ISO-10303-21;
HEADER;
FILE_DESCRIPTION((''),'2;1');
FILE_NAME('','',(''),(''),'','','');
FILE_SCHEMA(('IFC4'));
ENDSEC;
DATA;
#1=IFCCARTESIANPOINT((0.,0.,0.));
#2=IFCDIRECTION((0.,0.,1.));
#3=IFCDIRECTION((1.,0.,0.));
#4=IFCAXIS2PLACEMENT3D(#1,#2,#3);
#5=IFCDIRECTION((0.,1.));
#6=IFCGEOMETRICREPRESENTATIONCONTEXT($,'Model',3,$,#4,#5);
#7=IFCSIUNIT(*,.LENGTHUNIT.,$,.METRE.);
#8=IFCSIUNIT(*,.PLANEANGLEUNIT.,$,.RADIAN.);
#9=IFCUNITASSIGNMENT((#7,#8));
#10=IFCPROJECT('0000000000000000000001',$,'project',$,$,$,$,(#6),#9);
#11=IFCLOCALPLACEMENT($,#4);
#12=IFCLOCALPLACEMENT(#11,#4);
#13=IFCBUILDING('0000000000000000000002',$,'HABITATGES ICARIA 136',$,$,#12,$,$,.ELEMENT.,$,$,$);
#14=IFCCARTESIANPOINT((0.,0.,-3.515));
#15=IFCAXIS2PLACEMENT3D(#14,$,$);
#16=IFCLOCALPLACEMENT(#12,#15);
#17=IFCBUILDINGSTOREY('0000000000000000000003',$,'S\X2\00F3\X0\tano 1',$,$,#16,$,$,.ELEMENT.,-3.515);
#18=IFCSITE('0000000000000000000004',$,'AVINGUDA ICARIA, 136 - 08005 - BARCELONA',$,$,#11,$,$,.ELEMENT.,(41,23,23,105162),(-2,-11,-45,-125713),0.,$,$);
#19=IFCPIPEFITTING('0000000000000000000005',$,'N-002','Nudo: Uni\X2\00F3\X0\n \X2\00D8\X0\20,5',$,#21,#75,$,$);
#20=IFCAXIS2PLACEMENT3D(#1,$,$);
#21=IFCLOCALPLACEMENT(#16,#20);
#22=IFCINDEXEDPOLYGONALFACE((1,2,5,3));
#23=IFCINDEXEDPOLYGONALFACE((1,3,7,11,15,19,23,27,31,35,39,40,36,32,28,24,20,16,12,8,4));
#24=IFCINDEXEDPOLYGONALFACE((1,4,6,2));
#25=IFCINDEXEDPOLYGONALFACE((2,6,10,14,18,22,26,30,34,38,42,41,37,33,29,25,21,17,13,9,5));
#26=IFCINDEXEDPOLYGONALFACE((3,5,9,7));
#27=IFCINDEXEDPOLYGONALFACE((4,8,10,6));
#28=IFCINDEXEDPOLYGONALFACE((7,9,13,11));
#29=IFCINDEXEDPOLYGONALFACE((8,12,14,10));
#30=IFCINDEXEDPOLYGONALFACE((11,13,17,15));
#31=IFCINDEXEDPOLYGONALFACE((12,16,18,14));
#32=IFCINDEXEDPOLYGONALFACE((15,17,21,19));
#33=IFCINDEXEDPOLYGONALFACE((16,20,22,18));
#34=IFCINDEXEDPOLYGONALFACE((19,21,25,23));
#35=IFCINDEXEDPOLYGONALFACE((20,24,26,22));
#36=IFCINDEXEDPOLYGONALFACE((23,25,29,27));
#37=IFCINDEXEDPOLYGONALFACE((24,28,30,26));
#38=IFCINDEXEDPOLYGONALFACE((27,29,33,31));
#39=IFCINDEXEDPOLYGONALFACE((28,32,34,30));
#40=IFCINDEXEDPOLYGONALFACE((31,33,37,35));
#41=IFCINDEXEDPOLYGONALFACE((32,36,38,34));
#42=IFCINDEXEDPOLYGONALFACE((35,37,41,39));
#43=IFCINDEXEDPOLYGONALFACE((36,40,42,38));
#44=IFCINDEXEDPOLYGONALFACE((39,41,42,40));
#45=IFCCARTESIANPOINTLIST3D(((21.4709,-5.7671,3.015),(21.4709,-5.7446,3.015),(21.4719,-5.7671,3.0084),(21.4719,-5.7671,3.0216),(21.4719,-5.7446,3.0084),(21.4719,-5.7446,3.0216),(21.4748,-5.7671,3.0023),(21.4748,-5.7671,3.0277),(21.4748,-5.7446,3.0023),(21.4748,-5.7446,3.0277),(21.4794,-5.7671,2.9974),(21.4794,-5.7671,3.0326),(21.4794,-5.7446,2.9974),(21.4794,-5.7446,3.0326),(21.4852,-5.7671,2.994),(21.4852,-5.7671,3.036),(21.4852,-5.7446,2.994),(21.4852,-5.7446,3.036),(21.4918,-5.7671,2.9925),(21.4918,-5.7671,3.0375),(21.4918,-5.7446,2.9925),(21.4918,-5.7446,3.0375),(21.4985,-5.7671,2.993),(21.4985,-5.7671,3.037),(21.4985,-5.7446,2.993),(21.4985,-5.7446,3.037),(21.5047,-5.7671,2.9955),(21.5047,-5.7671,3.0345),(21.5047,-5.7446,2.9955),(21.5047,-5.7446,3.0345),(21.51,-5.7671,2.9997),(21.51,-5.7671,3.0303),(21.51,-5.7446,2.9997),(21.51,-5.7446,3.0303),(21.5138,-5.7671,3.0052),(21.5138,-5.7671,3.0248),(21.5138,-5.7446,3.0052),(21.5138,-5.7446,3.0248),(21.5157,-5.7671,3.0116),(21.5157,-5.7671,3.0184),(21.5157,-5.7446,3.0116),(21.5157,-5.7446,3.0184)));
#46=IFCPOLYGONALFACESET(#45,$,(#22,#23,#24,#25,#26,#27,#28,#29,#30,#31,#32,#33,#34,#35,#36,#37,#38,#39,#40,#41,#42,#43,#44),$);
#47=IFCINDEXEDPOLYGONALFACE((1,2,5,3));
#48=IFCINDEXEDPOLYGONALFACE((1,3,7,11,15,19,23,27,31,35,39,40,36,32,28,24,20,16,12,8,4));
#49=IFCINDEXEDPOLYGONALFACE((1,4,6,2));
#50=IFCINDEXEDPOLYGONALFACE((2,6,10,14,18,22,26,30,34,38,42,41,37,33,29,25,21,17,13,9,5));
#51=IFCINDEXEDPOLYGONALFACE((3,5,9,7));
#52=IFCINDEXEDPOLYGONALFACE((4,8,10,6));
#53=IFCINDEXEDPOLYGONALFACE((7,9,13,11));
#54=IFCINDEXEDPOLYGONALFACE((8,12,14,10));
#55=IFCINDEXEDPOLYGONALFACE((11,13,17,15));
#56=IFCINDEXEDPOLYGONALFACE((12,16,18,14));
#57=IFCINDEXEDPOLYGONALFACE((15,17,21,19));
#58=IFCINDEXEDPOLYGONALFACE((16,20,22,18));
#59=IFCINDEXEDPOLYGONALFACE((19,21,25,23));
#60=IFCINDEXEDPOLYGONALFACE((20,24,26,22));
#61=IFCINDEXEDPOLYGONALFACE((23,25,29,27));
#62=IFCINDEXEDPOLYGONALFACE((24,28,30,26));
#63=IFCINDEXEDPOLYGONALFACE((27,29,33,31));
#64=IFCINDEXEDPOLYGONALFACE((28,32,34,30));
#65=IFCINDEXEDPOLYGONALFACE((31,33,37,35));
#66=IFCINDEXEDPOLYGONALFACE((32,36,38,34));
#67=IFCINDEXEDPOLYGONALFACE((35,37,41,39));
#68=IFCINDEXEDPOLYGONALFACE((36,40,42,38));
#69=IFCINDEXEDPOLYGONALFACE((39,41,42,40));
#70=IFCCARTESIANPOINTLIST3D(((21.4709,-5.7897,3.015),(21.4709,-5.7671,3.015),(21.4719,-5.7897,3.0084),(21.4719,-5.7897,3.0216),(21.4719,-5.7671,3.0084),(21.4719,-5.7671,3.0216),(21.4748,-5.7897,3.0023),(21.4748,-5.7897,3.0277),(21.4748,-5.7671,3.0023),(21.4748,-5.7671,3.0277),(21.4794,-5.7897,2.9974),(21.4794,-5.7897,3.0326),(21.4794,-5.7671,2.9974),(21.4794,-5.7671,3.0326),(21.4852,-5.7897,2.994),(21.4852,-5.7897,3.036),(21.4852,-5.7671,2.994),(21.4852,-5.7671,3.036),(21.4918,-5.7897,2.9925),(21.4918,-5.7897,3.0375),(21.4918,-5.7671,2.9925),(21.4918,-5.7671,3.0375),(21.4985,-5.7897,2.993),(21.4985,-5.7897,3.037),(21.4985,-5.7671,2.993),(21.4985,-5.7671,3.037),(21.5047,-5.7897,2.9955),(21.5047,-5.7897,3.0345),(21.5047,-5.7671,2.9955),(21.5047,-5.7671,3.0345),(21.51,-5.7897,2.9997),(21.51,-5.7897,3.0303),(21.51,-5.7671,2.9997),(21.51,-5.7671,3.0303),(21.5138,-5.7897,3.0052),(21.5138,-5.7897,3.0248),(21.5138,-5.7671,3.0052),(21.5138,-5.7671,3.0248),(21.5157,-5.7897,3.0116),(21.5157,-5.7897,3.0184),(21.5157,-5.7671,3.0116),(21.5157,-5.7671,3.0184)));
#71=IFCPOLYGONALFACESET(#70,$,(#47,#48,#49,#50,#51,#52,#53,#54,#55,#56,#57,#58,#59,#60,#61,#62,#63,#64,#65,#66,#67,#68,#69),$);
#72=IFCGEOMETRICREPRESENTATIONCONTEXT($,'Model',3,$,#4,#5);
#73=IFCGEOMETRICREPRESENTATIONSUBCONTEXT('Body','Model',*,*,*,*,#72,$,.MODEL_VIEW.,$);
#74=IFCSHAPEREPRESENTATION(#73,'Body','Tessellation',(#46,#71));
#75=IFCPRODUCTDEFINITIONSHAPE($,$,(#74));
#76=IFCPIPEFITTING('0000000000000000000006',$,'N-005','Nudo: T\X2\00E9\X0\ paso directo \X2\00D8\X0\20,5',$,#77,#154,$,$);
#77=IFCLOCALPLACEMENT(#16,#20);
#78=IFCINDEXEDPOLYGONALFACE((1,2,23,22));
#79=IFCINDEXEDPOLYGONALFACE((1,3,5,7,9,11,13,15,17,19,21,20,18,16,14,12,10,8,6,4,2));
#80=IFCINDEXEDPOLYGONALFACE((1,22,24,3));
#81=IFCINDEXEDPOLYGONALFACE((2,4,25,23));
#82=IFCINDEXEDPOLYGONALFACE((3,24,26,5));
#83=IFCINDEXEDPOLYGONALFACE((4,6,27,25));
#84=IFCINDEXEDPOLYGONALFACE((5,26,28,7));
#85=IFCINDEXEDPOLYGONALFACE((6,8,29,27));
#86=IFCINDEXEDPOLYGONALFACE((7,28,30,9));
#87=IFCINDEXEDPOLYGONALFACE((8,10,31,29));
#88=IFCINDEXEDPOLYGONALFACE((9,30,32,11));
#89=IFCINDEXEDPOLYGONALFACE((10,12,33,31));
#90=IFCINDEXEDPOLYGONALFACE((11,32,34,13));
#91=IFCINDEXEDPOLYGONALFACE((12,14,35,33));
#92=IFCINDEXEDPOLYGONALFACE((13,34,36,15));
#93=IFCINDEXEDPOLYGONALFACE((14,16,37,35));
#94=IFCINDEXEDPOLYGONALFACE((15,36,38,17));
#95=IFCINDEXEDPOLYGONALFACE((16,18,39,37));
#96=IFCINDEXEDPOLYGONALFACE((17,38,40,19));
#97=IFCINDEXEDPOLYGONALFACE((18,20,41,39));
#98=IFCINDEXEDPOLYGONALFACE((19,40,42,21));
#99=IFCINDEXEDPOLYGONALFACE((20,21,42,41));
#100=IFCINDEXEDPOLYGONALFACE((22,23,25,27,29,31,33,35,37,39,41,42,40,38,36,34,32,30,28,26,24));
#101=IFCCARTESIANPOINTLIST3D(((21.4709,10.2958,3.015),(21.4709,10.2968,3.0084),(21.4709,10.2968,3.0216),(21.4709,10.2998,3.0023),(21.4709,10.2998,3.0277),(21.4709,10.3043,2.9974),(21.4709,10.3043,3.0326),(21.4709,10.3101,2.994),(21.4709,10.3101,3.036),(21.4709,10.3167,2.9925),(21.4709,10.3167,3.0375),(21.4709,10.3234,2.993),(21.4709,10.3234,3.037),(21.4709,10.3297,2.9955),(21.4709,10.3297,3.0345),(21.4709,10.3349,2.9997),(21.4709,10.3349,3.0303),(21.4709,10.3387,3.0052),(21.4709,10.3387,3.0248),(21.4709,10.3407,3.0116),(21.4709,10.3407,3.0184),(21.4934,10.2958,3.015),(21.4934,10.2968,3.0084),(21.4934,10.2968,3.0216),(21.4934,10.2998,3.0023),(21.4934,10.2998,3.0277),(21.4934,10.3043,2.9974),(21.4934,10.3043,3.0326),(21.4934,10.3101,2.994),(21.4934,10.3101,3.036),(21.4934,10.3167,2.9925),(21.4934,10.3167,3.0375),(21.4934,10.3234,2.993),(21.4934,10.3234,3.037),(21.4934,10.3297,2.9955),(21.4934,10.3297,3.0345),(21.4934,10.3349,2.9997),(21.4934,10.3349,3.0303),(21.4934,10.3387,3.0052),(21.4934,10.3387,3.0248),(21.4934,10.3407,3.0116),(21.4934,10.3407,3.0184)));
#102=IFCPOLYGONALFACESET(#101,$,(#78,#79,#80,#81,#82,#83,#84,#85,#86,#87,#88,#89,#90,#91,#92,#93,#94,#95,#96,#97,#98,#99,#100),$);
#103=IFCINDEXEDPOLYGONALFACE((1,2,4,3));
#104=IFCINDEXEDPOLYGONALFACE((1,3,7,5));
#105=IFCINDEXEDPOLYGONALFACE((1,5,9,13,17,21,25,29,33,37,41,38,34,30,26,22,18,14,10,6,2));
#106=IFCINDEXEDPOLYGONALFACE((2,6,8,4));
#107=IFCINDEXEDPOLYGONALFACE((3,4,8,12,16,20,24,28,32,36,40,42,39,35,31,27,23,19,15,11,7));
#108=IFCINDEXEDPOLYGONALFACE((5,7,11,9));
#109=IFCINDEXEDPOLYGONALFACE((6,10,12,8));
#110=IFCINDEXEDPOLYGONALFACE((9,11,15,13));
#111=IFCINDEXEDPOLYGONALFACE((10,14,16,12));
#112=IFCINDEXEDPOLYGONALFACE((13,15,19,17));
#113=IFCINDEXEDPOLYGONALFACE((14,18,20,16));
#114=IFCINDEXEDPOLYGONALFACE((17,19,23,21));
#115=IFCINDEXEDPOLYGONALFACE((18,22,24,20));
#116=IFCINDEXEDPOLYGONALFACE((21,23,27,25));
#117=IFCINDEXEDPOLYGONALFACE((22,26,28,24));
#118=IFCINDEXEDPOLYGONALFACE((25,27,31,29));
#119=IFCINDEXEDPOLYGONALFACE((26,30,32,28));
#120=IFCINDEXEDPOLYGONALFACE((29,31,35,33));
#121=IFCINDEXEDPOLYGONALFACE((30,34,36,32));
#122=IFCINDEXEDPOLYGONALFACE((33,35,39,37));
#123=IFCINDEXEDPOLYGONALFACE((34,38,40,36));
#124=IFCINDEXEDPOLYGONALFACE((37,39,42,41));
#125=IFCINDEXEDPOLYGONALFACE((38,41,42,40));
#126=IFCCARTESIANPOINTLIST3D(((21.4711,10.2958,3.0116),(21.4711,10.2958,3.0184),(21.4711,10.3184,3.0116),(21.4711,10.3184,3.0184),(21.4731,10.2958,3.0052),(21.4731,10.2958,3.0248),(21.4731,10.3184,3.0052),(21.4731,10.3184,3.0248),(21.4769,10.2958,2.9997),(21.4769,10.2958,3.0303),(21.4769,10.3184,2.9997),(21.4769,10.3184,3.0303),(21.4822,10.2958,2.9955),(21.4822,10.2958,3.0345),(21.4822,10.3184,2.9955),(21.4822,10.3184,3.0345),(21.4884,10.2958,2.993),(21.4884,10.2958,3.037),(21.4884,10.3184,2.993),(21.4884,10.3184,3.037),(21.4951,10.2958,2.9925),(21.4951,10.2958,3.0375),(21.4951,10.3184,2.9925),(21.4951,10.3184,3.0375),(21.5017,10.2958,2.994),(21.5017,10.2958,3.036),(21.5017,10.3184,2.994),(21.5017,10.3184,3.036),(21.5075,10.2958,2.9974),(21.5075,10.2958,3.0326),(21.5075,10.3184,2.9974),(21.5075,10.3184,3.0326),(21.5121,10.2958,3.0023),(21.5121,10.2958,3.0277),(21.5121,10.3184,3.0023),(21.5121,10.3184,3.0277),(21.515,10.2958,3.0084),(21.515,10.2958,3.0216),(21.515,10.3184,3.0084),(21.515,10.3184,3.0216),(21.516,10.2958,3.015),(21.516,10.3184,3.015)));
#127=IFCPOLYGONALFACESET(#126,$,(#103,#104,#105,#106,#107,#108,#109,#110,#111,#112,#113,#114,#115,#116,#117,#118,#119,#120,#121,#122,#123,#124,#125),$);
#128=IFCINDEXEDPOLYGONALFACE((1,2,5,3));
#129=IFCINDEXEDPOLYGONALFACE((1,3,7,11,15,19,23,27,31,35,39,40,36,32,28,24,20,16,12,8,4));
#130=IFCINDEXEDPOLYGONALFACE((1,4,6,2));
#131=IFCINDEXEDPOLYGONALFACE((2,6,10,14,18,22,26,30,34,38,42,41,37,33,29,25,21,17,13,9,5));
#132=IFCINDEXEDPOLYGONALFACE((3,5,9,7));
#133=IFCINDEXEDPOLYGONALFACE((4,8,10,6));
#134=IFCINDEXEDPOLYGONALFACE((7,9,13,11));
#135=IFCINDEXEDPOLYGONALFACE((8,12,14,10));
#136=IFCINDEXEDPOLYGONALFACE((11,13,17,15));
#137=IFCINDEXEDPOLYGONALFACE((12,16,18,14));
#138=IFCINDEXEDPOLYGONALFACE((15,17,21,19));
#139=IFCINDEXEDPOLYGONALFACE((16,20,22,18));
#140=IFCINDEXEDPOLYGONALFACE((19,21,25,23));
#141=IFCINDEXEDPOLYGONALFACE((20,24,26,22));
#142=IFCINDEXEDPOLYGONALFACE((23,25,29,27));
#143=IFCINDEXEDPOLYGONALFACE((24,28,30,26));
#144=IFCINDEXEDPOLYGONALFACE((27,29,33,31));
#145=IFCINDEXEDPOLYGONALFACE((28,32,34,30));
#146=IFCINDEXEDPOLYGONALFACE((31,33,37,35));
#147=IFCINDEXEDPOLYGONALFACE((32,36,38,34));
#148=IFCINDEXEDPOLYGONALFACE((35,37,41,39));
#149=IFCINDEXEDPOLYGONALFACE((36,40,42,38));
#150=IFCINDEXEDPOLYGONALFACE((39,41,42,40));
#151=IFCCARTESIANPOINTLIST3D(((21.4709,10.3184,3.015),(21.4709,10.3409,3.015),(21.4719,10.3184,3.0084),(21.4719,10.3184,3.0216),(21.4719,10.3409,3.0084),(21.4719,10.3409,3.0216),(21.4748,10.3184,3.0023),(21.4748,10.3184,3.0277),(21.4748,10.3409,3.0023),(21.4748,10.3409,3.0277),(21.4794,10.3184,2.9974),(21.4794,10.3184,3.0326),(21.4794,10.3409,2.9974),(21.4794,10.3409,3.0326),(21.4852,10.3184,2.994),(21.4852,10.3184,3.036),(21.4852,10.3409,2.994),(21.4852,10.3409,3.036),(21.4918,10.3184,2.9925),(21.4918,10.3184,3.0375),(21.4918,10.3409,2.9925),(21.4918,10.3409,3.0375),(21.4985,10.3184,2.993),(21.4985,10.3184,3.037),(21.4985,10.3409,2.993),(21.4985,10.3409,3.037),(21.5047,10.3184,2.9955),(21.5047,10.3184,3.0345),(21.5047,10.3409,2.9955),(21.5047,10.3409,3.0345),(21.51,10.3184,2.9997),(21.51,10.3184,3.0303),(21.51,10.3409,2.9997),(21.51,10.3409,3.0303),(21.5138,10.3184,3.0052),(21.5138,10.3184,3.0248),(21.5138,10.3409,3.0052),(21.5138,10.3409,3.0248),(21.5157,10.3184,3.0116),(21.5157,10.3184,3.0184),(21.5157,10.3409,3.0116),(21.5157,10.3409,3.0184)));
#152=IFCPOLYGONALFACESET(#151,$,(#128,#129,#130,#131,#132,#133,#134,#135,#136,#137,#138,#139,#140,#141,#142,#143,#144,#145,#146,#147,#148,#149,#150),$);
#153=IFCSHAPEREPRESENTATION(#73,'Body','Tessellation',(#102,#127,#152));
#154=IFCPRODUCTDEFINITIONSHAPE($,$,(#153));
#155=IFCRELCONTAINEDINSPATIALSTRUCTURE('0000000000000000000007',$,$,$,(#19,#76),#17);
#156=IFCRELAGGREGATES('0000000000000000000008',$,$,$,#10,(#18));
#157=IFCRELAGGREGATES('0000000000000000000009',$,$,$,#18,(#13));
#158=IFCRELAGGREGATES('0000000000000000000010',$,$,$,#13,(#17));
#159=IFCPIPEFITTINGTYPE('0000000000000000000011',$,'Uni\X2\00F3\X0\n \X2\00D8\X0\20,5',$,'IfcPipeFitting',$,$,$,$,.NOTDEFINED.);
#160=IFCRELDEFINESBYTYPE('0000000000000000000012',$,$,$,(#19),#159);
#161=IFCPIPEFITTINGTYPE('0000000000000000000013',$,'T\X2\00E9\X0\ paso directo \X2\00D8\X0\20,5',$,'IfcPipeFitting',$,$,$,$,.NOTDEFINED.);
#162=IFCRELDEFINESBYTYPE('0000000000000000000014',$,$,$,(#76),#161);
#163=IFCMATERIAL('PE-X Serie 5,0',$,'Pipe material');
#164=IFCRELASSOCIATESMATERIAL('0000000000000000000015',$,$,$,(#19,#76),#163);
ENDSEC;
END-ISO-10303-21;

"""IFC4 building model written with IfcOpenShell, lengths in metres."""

from ifc_helpers import new_model, si_unit, direction, frame, origin_with_axes, origin_2d_with_axis, place, context, subcontext, project, spatial, circle, extrude, source, transform, mapped, material, type_object, element, save


model = new_model("IFC4")

# Units and contexts
model_context_1 = context("Model", 3, world=origin_with_axes(), true_north=direction((0.0, 1.0)))
model_context_2 = context("Model", 3, world=origin_with_axes(), true_north=direction((0.0, 1.0)))
body_context_1 = subcontext(model_context_2, "Body", "Model", "MODEL_VIEW")
ifc_project = project(units=[si_unit("LENGTHUNIT", "METRE"), si_unit("PLANEANGLEUNIT", "RADIAN")], contexts=[model_context_1])

# Site, building, storey
site_placement = place(None, origin_with_axes())
site = spatial("IfcSite", under=ifc_project, at=site_placement, Name="AVINGUDA ICARIA, 136 - 08005 - BARCELONA", CompositionType="ELEMENT", RefLatitude=(41, 23, 23, 105162), RefLongitude=(-2, -11, -45, -125713), RefElevation=0.0)
building_placement = place(site_placement, origin_with_axes())
building = spatial("IfcBuilding", under=site, at=building_placement, Name="HABITATGES ICARIA 136", CompositionType="ELEMENT")
storey_placement = place(building_placement, frame((0.0, 0.0, -3.515)))
storey = spatial("IfcBuildingStorey", under=building, at=storey_placement, Name="Sótano 1", CompositionType="ELEMENT", Elevation=-3.515)

# Shared definitions
ifc_material_1 = material(Name="PE-X Serie 5,0", Category="Pipe material")
placement_1 = place(None, origin_with_axes())
placement_2 = place(placement_1, origin_with_axes())
placement_3 = place(placement_2, frame((0.0, 0.0, -3.515)))

# Pipe fitting
pipe_fitting_type_1 = type_object("IfcPipeFittingType", Name="Unión Ø20,5", ApplicableOccurrence="IfcPipeFitting", PredefinedType="NOTDEFINED")
shared_shape_1 = source(origin_with_axes(), body_context_1, "Body", "SweptSolid", [
    extrude(circle(Radius=0.0226, at=origin_2d_with_axis()), frame((0.0, 0.0, 0.0), z_axis=(0.0, 1.0, 0.0), x_axis=(-1.0, 0.0, 0.0)), (0.0, 0.0, 1.0), 0.0226),
    extrude(circle(Radius=0.0226, at=origin_2d_with_axis()), frame((0.0, -0.0226, 0.0), z_axis=(0.0, 1.0, 0.0), x_axis=(-1.0, 0.0, 0.0)), (0.0, 0.0, 1.0), 0.0226),
])
pipe_fitting_1_placement = place(placement_3, origin_with_axes())
element("IfcPipeFitting", 1, at=pipe_fitting_1_placement, inside=storey, type_object=pipe_fitting_type_1, material=ifc_material_1, Name="N-002", Description="Nudo: Unión Ø20,5", context=body_context_1, shape_type="MappedRepresentation", body=[
    mapped(shared_shape_1, transform((21.4934, -5.7671, 3.015), x_axis=(1.0, 0.0, 0.0), y_axis=(0.0, 1.0, 0.0), z_axis=(0.0, 0.0, 1.0), scale=1.0)),
])

# Pipe fitting
pipe_fitting_type_2 = type_object("IfcPipeFittingType", Name="Té paso directo Ø20,5", ApplicableOccurrence="IfcPipeFitting", PredefinedType="NOTDEFINED")
shared_shape_2 = source(origin_with_axes(), body_context_1, "Body", "SweptSolid", [
    extrude(circle(Radius=0.0226, at=origin_2d_with_axis()), frame((0.0, 0.0, 0.0), z_axis=(-1.0, 0.0, 0.0), x_axis=(0.0, -1.0, 0.0)), (0.0, 0.0, 1.0), 0.0226),
    extrude(circle(Radius=0.0226, at=origin_2d_with_axis()), frame((0.0, 0.0, 0.0), z_axis=(0.0, -1.0, 0.0), x_axis=(1.0, 0.0, 0.0)), (0.0, 0.0, 1.0), 0.0226),
    extrude(circle(Radius=0.0226, at=origin_2d_with_axis()), frame((0.0, 0.0, 0.0), z_axis=(0.0, 1.0, 0.0), x_axis=(-1.0, 0.0, 0.0)), (0.0, 0.0, 1.0), 0.0226),
])
pipe_fitting_2_placement = place(placement_3, origin_with_axes())
element("IfcPipeFitting", 2, at=pipe_fitting_2_placement, inside=storey, type_object=pipe_fitting_type_2, material=ifc_material_1, Name="N-005", Description="Nudo: Té paso directo Ø20,5", context=body_context_1, shape_type="MappedRepresentation", body=[
    mapped(shared_shape_2, transform((21.4934, 10.3184, 3.015), x_axis=(1.0, 0.0, 0.0), y_axis=(0.0, 1.0, 0.0), z_axis=(0.0, 0.0, 1.0), scale=1.0)),
])

save(model, "model.ifc")
